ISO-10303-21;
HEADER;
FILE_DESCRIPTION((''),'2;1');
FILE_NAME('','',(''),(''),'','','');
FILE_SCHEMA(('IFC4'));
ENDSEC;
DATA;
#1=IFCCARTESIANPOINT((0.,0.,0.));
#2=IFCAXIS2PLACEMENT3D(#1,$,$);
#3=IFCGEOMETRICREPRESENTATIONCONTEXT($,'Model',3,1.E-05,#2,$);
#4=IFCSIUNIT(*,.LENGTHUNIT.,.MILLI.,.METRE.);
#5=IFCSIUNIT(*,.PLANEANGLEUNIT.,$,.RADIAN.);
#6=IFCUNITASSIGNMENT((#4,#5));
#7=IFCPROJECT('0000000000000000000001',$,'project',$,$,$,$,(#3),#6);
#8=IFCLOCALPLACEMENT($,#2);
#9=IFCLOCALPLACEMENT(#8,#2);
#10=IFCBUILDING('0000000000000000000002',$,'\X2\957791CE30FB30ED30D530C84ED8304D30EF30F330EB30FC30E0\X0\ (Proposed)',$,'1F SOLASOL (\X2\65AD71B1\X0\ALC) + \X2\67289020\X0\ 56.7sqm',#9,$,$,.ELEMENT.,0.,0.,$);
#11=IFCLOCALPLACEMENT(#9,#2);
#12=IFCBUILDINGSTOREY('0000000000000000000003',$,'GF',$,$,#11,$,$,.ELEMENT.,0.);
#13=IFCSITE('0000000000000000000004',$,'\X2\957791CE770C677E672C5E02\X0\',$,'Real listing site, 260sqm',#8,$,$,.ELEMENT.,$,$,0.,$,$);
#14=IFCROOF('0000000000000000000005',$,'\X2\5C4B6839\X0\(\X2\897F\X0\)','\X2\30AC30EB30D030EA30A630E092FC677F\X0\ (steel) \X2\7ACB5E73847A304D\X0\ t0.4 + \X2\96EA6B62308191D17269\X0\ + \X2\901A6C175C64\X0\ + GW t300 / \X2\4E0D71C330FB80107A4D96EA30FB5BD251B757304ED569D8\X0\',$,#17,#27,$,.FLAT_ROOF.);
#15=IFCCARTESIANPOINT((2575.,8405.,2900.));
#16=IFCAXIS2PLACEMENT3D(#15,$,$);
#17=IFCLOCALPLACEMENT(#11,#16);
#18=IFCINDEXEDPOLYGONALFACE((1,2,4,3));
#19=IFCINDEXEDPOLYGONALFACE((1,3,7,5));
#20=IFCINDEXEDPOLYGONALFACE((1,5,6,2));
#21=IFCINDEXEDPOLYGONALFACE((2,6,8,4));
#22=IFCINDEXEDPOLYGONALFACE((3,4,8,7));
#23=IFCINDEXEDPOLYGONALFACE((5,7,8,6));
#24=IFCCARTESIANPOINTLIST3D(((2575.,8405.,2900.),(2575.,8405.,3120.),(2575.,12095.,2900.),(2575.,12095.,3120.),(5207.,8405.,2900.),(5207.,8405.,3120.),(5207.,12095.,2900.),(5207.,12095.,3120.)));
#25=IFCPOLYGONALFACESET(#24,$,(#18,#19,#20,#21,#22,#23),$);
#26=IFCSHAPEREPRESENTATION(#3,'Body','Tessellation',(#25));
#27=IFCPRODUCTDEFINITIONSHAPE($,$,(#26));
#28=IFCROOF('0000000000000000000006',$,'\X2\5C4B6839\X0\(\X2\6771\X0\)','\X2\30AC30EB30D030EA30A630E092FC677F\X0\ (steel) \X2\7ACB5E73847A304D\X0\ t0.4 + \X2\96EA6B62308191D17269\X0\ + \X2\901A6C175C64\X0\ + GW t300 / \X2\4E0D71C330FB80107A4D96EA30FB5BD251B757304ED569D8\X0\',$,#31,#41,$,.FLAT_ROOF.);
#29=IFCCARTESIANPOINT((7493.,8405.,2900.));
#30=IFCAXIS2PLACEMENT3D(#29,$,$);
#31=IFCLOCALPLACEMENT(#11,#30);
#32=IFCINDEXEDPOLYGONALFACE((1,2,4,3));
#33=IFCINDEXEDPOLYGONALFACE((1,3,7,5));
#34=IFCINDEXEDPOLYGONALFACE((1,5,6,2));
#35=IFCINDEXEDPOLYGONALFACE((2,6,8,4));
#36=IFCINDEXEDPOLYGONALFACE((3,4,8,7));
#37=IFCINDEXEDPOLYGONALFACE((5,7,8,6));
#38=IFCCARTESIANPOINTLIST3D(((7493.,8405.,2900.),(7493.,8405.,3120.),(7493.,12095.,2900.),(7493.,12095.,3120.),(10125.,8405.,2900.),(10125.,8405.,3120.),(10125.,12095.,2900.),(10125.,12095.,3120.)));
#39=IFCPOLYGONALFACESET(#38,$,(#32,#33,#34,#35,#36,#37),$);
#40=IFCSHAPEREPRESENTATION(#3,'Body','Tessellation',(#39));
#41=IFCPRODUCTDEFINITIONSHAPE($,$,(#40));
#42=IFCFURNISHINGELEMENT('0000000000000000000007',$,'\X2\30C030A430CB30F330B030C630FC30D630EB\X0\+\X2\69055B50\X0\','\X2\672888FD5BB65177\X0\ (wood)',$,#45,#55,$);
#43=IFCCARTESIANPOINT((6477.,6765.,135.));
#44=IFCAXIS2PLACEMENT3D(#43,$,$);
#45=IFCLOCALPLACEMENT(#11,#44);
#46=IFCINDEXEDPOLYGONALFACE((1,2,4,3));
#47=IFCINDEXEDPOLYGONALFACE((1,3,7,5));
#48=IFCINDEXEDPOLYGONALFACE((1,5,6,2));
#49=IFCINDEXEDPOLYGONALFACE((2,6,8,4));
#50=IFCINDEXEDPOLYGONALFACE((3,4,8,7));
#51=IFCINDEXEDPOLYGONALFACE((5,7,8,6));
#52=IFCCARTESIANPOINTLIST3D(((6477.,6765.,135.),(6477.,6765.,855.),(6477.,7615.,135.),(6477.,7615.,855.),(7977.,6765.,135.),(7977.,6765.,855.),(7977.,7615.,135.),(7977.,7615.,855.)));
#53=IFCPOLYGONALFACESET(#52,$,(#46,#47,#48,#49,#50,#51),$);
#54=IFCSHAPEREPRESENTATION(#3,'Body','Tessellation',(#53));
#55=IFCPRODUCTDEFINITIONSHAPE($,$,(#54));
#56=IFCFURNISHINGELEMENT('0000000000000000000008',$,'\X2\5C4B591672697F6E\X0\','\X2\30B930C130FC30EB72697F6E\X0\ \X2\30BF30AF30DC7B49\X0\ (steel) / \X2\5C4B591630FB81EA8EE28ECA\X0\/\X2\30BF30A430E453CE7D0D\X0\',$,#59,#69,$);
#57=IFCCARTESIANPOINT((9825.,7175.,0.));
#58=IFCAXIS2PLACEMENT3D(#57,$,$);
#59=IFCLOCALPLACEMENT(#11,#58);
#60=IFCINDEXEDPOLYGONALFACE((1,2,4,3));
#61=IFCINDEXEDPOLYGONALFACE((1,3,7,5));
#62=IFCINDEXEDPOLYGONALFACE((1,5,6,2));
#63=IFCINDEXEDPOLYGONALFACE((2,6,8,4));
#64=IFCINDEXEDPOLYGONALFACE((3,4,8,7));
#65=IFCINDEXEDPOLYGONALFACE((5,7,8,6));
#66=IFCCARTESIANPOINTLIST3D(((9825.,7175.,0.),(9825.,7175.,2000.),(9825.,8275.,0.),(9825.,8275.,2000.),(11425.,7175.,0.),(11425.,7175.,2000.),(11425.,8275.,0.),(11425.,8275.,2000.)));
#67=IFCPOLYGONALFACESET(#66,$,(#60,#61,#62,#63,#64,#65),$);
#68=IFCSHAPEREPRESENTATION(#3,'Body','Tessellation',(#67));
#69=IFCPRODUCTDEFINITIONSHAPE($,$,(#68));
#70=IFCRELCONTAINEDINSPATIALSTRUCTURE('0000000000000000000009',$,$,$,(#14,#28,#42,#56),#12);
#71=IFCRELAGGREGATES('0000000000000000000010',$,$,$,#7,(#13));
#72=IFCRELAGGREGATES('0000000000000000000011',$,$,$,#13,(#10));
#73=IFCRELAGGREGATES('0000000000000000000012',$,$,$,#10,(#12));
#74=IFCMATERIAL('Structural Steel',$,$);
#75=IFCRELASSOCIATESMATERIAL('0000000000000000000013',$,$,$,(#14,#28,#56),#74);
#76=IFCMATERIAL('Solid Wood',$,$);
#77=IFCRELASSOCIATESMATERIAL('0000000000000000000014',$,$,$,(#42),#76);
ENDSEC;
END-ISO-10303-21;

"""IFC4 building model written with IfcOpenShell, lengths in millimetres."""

from ifc_helpers import new_model, si_unit, frame, frame_2d, origin, place, context, project, spatial, rectangle, extrude, material, element, save


model = new_model("IFC4")

# Units and contexts
model_context = context("Model", 3, precision=1e-05, world=origin())
ifc_project = project(units=[si_unit("LENGTHUNIT", "METRE", prefix="MILLI"), si_unit("PLANEANGLEUNIT", "RADIAN")], contexts=[model_context])

# Site, building, storey
site_placement = place(None, origin())
site = spatial("IfcSite", under=ifc_project, at=site_placement, Name="長野県松本市", ObjectType="Real listing site, 260sqm", CompositionType="ELEMENT", RefElevation=0.0)
building_placement = place(site_placement, origin())
building = spatial("IfcBuilding", under=site, at=building_placement, Name="長野・ロフト付きワンルーム (Proposed)", ObjectType="1F SOLASOL (断熱ALC) + 木造 56.7sqm", CompositionType="ELEMENT", ElevationOfRefHeight=0.0, ElevationOfTerrain=0.0)
storey_placement = place(building_placement, origin())
storey = spatial("IfcBuildingStorey", under=building, at=storey_placement, Name="GF", CompositionType="ELEMENT", Elevation=0.0)

# Shared definitions
ifc_material_1 = material(Name="Solid Wood")

# Roofs
ifc_material_2 = material(Name="Structural Steel")
roof_1_placement = place(storey_placement, frame((2575.0, 8405.0, 2900.0)))
element("IfcRoof", 1, at=roof_1_placement, inside=storey, material=ifc_material_2, Name="屋根(西)", Description="ガルバリウム鋼板 (steel) 立平葺き t0.4 + 雪止め金物 + 通気層 + GW t300 / 不燃・耐積雪・寒冷地仕様", PredefinedType="FLAT_ROOF", context=model_context, shape_type="SweptSolid", body=[
    extrude(rectangle(XDim=2632.0, YDim=3690.0, at=frame_2d((1316.0, 1845.0))), frame((2575.0, 8405.0, 2900.0)), (0.0, 0.0, 1.0), 220.0),
])
roof_2_placement = place(storey_placement, frame((7493.0, 8405.0, 2900.0)))
element("IfcRoof", 2, at=roof_2_placement, inside=storey, material=ifc_material_2, Name="屋根(東)", Description="ガルバリウム鋼板 (steel) 立平葺き t0.4 + 雪止め金物 + 通気層 + GW t300 / 不燃・耐積雪・寒冷地仕様", PredefinedType="FLAT_ROOF", context=model_context, shape_type="SweptSolid", body=[
    extrude(rectangle(XDim=2632.0, YDim=3690.0, at=frame_2d((1316.0, 1845.0))), frame((7493.0, 8405.0, 2900.0)), (0.0, 0.0, 1.0), 220.0),
])

# Furnishing elements
furnishing_1_placement = place(storey_placement, frame((6477.0, 6765.0, 135.0)))
element("IfcFurnishingElement", 3, at=furnishing_1_placement, inside=storey, material=ifc_material_1, Name="ダイニングテーブル+椅子", Description="木製家具 (wood)", context=model_context, shape_type="SweptSolid", body=[
    extrude(rectangle(XDim=1500.0, YDim=850.0, at=frame_2d((750.0, 425.0))), frame((6477.0, 6765.0, 135.0)), (0.0, 0.0, 1.0), 720.0),
])
furnishing_2_placement = place(storey_placement, frame((9825.0, 7175.0, 0.0)))
element("IfcFurnishingElement", 4, at=furnishing_2_placement, inside=storey, material=ifc_material_2, Name="屋外物置", Description="スチール物置 タクボ等 (steel) / 屋外・自転車/タイヤ収納", context=model_context, shape_type="SweptSolid", body=[
    extrude(rectangle(XDim=1600.0, YDim=1100.0, at=frame_2d((800.0, 550.0))), frame((9825.0, 7175.0, 0.0)), (0.0, 0.0, 1.0), 2000.0),
])

save(model, "model.ifc")
